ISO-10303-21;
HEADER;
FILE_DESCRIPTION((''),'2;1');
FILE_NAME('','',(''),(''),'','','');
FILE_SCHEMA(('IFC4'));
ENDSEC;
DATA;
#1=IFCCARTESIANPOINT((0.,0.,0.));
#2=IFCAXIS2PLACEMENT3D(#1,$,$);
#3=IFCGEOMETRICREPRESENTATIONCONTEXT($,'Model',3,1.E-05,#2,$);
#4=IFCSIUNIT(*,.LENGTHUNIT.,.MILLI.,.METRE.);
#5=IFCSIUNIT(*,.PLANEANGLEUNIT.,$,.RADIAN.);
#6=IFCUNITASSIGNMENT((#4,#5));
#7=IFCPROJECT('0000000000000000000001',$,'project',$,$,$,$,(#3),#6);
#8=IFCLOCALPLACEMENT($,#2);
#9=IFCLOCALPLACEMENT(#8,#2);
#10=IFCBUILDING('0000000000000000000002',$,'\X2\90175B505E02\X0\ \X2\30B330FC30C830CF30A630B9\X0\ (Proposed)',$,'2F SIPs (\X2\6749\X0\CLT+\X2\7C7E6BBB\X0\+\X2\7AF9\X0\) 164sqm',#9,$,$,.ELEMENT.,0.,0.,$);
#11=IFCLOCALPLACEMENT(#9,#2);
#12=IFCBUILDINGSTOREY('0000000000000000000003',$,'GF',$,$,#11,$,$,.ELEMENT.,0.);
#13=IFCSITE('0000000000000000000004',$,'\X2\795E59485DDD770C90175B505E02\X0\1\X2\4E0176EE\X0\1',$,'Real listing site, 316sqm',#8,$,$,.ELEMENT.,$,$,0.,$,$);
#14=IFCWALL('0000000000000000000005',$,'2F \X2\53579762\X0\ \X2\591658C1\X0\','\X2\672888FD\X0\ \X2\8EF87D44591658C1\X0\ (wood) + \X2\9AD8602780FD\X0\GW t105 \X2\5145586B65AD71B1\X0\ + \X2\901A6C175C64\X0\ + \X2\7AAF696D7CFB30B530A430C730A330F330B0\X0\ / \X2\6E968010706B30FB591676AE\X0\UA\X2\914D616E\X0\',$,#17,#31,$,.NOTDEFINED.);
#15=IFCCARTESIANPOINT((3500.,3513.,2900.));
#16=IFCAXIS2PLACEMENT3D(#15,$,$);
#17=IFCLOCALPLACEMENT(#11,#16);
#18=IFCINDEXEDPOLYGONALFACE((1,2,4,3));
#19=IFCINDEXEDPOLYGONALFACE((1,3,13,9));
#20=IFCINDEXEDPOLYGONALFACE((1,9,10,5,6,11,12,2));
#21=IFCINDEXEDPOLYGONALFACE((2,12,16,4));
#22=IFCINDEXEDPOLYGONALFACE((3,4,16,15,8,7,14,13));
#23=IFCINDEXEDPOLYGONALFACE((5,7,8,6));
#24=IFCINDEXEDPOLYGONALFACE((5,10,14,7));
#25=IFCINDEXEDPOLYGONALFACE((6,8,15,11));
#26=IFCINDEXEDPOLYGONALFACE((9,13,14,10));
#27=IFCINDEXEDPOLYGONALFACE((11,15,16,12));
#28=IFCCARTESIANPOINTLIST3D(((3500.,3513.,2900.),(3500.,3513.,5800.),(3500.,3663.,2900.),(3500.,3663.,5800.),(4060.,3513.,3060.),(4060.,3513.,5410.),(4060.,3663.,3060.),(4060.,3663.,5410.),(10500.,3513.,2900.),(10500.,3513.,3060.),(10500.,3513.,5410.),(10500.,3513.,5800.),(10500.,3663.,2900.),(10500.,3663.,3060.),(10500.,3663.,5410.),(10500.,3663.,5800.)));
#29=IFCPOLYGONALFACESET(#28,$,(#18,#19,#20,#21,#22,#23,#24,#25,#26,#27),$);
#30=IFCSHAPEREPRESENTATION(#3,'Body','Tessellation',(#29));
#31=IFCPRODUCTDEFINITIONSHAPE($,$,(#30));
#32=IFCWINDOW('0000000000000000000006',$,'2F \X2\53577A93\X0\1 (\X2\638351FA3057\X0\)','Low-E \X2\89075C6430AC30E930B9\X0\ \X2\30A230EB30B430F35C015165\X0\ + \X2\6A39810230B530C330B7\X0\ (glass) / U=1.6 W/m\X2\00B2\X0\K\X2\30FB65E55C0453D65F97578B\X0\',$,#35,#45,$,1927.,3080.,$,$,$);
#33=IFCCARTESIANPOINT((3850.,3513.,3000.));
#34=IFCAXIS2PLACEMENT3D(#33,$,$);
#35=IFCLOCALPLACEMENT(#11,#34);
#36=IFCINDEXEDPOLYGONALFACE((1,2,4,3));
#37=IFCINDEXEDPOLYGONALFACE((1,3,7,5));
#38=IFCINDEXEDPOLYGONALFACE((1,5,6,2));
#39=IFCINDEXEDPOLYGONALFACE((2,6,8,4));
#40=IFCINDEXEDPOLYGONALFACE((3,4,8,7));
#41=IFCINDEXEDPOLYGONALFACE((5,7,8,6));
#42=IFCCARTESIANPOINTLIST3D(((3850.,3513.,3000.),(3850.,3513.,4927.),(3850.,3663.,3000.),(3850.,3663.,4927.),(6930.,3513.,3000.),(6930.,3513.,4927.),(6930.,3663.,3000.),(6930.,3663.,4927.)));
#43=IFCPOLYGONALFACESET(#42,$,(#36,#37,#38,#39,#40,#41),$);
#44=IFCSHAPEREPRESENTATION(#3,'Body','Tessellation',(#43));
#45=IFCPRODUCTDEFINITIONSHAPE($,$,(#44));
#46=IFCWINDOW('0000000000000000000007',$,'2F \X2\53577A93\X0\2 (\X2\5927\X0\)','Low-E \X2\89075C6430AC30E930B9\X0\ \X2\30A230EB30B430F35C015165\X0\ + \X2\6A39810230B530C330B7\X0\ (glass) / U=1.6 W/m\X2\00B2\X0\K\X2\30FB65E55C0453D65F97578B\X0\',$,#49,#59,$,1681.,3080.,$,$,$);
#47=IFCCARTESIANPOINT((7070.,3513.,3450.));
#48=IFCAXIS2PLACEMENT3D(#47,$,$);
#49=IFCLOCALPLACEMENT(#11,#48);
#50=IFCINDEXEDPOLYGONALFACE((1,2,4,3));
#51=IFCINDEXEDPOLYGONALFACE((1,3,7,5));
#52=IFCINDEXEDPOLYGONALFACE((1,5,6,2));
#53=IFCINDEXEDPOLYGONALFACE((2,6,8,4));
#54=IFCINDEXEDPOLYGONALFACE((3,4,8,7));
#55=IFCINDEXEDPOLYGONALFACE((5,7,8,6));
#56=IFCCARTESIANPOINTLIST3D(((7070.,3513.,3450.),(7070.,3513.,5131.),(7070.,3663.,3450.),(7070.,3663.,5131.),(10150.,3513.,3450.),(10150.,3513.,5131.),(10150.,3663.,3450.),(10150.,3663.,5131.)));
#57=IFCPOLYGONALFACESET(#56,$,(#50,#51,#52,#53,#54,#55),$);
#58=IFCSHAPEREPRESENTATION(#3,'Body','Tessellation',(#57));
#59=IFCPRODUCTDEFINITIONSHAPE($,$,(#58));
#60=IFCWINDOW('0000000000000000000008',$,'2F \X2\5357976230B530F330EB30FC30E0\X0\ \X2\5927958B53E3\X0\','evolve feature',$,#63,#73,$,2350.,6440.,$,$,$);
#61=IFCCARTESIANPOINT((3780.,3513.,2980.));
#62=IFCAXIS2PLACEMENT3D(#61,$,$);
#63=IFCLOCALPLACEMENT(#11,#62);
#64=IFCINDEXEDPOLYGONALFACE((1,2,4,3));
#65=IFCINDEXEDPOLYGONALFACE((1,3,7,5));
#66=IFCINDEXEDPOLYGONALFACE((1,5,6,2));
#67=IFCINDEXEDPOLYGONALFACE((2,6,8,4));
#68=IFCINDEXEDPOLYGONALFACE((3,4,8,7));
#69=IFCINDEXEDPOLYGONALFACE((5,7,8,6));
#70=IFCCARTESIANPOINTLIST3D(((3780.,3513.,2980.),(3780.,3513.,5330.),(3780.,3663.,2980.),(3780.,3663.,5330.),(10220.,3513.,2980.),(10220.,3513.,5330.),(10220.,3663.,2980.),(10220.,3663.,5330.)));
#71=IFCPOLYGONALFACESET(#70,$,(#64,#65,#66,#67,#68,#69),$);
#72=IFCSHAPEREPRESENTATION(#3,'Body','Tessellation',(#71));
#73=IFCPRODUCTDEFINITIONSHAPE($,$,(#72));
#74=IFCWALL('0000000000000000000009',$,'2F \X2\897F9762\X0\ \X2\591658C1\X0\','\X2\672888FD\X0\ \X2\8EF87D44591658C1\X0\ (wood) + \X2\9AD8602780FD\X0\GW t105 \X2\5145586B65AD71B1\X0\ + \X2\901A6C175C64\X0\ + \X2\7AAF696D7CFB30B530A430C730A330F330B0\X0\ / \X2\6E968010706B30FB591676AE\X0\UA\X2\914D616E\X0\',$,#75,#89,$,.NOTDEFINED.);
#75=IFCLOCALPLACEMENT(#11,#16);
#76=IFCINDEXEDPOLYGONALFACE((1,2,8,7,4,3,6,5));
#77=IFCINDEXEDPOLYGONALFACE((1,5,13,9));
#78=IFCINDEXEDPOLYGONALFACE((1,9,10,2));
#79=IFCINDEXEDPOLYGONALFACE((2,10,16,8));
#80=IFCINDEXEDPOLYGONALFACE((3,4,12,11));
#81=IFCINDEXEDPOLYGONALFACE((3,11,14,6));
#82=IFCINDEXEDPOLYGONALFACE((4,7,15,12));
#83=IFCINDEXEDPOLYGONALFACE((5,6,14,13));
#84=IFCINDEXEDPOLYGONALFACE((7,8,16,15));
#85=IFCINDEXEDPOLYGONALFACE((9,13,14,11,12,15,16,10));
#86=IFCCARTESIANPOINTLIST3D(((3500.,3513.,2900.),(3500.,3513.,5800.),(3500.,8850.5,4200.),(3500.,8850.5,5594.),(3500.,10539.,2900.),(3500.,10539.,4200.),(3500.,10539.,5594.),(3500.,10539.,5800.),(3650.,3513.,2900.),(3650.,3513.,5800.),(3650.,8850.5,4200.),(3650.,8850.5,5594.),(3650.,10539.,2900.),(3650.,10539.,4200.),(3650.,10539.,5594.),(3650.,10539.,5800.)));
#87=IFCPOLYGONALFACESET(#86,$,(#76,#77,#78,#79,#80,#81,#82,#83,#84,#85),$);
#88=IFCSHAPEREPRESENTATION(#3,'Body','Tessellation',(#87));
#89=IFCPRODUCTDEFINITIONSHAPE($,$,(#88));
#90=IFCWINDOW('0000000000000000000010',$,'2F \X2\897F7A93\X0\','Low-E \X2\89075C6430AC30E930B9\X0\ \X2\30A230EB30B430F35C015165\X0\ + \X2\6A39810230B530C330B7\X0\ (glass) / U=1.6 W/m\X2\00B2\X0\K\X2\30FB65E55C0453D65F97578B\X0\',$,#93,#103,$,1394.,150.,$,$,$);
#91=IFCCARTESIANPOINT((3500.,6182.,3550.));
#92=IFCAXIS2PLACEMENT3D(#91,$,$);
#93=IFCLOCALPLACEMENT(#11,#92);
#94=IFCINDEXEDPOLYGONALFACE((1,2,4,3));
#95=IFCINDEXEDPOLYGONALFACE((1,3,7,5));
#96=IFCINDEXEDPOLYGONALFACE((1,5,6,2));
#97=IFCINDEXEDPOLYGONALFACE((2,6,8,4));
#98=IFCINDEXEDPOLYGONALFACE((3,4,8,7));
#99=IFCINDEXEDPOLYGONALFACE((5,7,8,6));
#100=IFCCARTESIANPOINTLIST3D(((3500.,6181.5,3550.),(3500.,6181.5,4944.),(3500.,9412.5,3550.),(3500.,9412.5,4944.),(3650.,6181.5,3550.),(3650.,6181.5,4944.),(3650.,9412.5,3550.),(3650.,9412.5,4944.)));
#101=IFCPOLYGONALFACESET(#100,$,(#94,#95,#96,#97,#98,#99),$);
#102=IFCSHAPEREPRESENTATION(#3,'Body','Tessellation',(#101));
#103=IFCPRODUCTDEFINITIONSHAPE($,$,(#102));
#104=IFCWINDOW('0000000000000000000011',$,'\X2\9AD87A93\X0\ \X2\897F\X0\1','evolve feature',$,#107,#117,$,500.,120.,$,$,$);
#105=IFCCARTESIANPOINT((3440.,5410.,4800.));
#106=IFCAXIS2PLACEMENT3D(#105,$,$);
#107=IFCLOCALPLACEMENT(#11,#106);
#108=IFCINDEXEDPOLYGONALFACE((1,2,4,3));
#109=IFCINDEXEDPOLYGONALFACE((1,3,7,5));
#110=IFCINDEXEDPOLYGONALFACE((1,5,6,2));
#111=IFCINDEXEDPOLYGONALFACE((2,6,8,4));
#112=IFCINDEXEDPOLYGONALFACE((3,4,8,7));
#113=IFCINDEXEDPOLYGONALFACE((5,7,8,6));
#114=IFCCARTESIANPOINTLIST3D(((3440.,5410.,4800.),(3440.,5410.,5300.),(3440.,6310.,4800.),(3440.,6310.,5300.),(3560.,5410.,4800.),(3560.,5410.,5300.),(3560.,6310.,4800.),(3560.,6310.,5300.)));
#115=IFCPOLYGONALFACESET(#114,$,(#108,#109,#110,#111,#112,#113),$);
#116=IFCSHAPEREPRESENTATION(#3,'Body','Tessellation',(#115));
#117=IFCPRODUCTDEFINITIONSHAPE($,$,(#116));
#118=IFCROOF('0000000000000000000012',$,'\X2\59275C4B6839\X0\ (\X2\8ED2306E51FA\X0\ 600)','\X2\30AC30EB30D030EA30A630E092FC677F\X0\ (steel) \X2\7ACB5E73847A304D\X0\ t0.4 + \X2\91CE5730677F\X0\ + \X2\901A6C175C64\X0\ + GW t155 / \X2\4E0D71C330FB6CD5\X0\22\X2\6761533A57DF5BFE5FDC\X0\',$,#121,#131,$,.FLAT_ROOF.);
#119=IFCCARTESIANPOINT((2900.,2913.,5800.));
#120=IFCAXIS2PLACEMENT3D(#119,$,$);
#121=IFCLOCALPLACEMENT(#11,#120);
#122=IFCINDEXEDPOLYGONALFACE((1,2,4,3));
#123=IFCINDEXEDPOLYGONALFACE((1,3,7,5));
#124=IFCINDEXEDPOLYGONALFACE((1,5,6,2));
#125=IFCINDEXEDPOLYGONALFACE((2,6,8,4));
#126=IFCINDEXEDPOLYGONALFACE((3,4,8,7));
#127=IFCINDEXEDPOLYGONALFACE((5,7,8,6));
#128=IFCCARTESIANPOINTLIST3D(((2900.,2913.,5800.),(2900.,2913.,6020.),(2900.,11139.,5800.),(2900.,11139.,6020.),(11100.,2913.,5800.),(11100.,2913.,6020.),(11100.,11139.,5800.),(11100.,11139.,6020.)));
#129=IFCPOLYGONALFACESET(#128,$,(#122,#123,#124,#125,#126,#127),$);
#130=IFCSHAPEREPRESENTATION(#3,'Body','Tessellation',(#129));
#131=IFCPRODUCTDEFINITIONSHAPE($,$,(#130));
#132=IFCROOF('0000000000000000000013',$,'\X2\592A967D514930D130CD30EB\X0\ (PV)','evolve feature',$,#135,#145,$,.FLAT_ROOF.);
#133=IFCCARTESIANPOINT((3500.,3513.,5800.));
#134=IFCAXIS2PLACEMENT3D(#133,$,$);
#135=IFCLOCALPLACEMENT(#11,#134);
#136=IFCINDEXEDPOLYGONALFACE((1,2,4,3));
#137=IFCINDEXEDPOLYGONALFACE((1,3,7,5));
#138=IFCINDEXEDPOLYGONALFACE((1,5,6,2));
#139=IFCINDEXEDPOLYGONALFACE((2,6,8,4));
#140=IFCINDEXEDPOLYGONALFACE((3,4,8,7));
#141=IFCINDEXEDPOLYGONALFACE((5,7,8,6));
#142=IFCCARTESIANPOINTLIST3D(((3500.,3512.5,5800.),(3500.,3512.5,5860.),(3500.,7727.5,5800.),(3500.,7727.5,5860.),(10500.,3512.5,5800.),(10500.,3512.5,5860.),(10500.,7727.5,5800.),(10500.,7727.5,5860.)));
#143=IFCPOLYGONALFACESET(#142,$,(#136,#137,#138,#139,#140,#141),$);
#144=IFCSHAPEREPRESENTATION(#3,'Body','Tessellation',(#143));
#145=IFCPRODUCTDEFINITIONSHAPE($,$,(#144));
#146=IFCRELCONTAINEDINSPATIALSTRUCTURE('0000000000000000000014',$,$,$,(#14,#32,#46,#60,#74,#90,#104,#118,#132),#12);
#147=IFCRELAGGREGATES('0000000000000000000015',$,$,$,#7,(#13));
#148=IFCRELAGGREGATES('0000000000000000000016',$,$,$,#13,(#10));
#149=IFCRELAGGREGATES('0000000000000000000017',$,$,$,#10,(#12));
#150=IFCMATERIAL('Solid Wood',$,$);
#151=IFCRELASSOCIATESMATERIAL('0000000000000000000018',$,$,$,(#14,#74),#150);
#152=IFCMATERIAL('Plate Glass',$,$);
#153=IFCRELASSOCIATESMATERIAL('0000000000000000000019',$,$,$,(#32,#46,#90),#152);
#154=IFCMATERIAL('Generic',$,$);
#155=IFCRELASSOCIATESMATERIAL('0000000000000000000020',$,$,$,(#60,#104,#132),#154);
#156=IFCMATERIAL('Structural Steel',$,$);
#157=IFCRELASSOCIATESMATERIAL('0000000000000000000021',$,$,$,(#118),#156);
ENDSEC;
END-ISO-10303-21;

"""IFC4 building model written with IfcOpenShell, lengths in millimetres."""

from ifc_helpers import new_model, si_unit, frame, frame_2d, origin, place, context, project, spatial, rectangle, extrude, material, element, fill, save


model = new_model("IFC4")

# Units and contexts
model_context = context("Model", 3, precision=1e-05, world=origin())
ifc_project = project(units=[si_unit("LENGTHUNIT", "METRE", prefix="MILLI"), si_unit("PLANEANGLEUNIT", "RADIAN")], contexts=[model_context])

# Site, building, storey
site_placement = place(None, origin())
site = spatial("IfcSite", under=ifc_project, at=site_placement, Name="神奈川県逗子市1丁目1", ObjectType="Real listing site, 316sqm", CompositionType="ELEMENT", RefElevation=0.0)
building_placement = place(site_placement, origin())
building = spatial("IfcBuilding", under=site, at=building_placement, Name="逗子市 コートハウス (Proposed)", ObjectType="2F SIPs (杉CLT+籾殻+竹) 164sqm", CompositionType="ELEMENT", ElevationOfRefHeight=0.0, ElevationOfTerrain=0.0)
storey_placement = place(building_placement, origin())
storey = spatial("IfcBuildingStorey", under=building, at=storey_placement, Name="GF", CompositionType="ELEMENT", Elevation=0.0)

# Shared definitions
ifc_material_1 = material(Name="Solid Wood")
ifc_material_2 = material(Name="Generic")

# Shared definitions
ifc_material_3 = material(Name="Plate Glass")

# Walls, openings, windows
wall_1_placement = place(storey_placement, frame((3500.0, 3513.0, 2900.0)))
wall_1 = element("IfcWall", 1, at=wall_1_placement, inside=storey, material=ifc_material_1, Name="2F 南面 外壁", Description="木製 軸組外壁 (wood) + 高性能GW t105 充填断熱 + 通気層 + 窯業系サイディング / 準耐火・外皮UA配慮", PredefinedType="NOTDEFINED", context=model_context, shape_type="SweptSolid", body=[
    extrude(rectangle(XDim=7000.0, YDim=150.0, at=frame_2d((3500.0, 75.0))), frame((3500.0, 3513.0, 2900.0)), (0.0, 0.0, 1.0), 2900.0),
])
opening_1_placement = place(storey_placement, frame((3850.0, 3513.0, 3000.0)))
opening_1 = element("IfcOpeningElement", 2, at=opening_1_placement, cuts=wall_1, PredefinedType="NOTDEFINED", context=model_context, shape_type="SweptSolid", body=[
    extrude(rectangle(XDim=3080.0, YDim=150.0, at=frame_2d((1540.0, 75.0))), frame((3850.0, 3513.0, 3000.0)), (0.0, 0.0, 1.0), 1927.0),
])
opening_2_placement = place(storey_placement, frame((7070.0, 3513.0, 3450.0)))
opening_2 = element("IfcOpeningElement", 3, at=opening_2_placement, cuts=wall_1, PredefinedType="NOTDEFINED", context=model_context, shape_type="SweptSolid", body=[
    extrude(rectangle(XDim=3080.0, YDim=150.0, at=frame_2d((1540.0, 75.0))), frame((7070.0, 3513.0, 3450.0)), (0.0, 0.0, 1.0), 1681.0),
])
opening_3_placement = place(storey_placement, frame((3780.0, 3513.0, 2980.0)))
opening_3 = element("IfcOpeningElement", 4, at=opening_3_placement, cuts=wall_1, PredefinedType="NOTDEFINED", context=model_context, shape_type="SweptSolid", body=[
    extrude(rectangle(XDim=6440.0, YDim=150.0, at=frame_2d((3220.0, 75.0))), frame((3780.0, 3513.0, 2980.0)), (0.0, 0.0, 1.0), 2350.0),
])
window_1_placement = place(storey_placement, frame((3850.0, 3513.0, 3000.0)))
window_1 = element("IfcWindow", 5, at=window_1_placement, inside=storey, material=ifc_material_3, Name="2F 南窓1 (掃出し)", Description="Low-E 複層ガラス アルゴン封入 + 樹脂サッシ (glass) / U=1.6 W/m²K・日射取得型", OverallHeight=1927.0, OverallWidth=3080.0, context=model_context, shape_type="SweptSolid", body=[
    extrude(rectangle(XDim=3080.0, YDim=150.0, at=frame_2d((1540.0, 75.0))), frame((3850.0, 3513.0, 3000.0)), (0.0, 0.0, 1.0), 1927.0),
])
fill(opening_1, window_1)
window_2_placement = place(storey_placement, frame((7070.0, 3513.0, 3450.0)))
window_2 = element("IfcWindow", 6, at=window_2_placement, inside=storey, material=ifc_material_3, Name="2F 南窓2 (大)", Description="Low-E 複層ガラス アルゴン封入 + 樹脂サッシ (glass) / U=1.6 W/m²K・日射取得型", OverallHeight=1681.0, OverallWidth=3080.0, context=model_context, shape_type="SweptSolid", body=[
    extrude(rectangle(XDim=3080.0, YDim=150.0, at=frame_2d((1540.0, 75.0))), frame((7070.0, 3513.0, 3450.0)), (0.0, 0.0, 1.0), 1681.0),
])
fill(opening_2, window_2)
window_3_placement = place(storey_placement, frame((3780.0, 3513.0, 2980.0)))
window_3 = element("IfcWindow", 7, at=window_3_placement, inside=storey, material=ifc_material_2, Name="2F 南面サンルーム 大開口", Description="evolve feature", OverallHeight=2350.0, OverallWidth=6440.0, context=model_context, shape_type="SweptSolid", body=[
    extrude(rectangle(XDim=6440.0, YDim=150.0, at=frame_2d((3220.0, 75.0))), frame((3780.0, 3513.0, 2980.0)), (0.0, 0.0, 1.0), 2350.0),
])
fill(opening_3, window_3)
wall_2_placement = place(storey_placement, frame((3500.0, 3513.0, 2900.0)))
wall_2 = element("IfcWall", 8, at=wall_2_placement, inside=storey, material=ifc_material_1, Name="2F 西面 外壁", Description="木製 軸組外壁 (wood) + 高性能GW t105 充填断熱 + 通気層 + 窯業系サイディング / 準耐火・外皮UA配慮", PredefinedType="NOTDEFINED", context=model_context, shape_type="SweptSolid", body=[
    extrude(rectangle(XDim=150.0, YDim=7026.0, at=frame_2d((75.0, 3513.0))), frame((3500.0, 3513.0, 2900.0)), (0.0, 0.0, 1.0), 2900.0),
])
opening_4_placement = place(storey_placement, frame((3500.0, 6182.0, 3550.0)))
opening_4 = element("IfcOpeningElement", 9, at=opening_4_placement, cuts=wall_2, PredefinedType="NOTDEFINED", context=model_context, shape_type="SweptSolid", body=[
    extrude(rectangle(XDim=150.0, YDim=3231.0, at=frame_2d((75.0, 1615.0))), frame((3500.0, 6182.0, 3550.0)), (0.0, 0.0, 1.0), 1394.0),
])
opening_5_placement = place(storey_placement, frame((3440.0, 5410.0, 4800.0)))
opening_5 = element("IfcOpeningElement", 10, at=opening_5_placement, cuts=wall_2, PredefinedType="NOTDEFINED", context=model_context, shape_type="SweptSolid", body=[
    extrude(rectangle(XDim=120.0, YDim=900.0, at=frame_2d((60.0, 450.0))), frame((3440.0, 5410.0, 4800.0)), (0.0, 0.0, 1.0), 500.0),
])
window_4_placement = place(storey_placement, frame((3500.0, 6182.0, 3550.0)))
window_4 = element("IfcWindow", 11, at=window_4_placement, inside=storey, material=ifc_material_3, Name="2F 西窓", Description="Low-E 複層ガラス アルゴン封入 + 樹脂サッシ (glass) / U=1.6 W/m²K・日射取得型", OverallHeight=1394.0, OverallWidth=150.0, context=model_context, shape_type="SweptSolid", body=[
    extrude(rectangle(XDim=150.0, YDim=3231.0, at=frame_2d((75.0, 1615.0))), frame((3500.0, 6182.0, 3550.0)), (0.0, 0.0, 1.0), 1394.0),
])
fill(opening_4, window_4)
window_5_placement = place(storey_placement, frame((3440.0, 5410.0, 4800.0)))
window_5 = element("IfcWindow", 12, at=window_5_placement, inside=storey, material=ifc_material_2, Name="高窓 西1", Description="evolve feature", OverallHeight=500.0, OverallWidth=120.0, context=model_context, shape_type="SweptSolid", body=[
    extrude(rectangle(XDim=120.0, YDim=900.0, at=frame_2d((60.0, 450.0))), frame((3440.0, 5410.0, 4800.0)), (0.0, 0.0, 1.0), 500.0),
])
fill(opening_5, window_5)

# Roofs
ifc_material_4 = material(Name="Structural Steel")
roof_1_placement = place(storey_placement, frame((2900.0, 2913.0, 5800.0)))
element("IfcRoof", 13, at=roof_1_placement, inside=storey, material=ifc_material_4, Name="大屋根 (軒の出 600)", Description="ガルバリウム鋼板 (steel) 立平葺き t0.4 + 野地板 + 通気層 + GW t155 / 不燃・法22条区域対応", PredefinedType="FLAT_ROOF", context=model_context, shape_type="SweptSolid", body=[
    extrude(rectangle(XDim=8200.0, YDim=8226.0, at=frame_2d((4100.0, 4113.0))), frame((2900.0, 2913.0, 5800.0)), (0.0, 0.0, 1.0), 220.0),
])
roof_2_placement = place(storey_placement, frame((3500.0, 3513.0, 5800.0)))
element("IfcRoof", 14, at=roof_2_placement, inside=storey, material=ifc_material_2, Name="太陽光パネル (PV)", Description="evolve feature", PredefinedType="FLAT_ROOF", context=model_context, shape_type="SweptSolid", body=[
    extrude(rectangle(XDim=7000.0, YDim=4215.0, at=frame_2d((3500.0, 2107.0))), frame((3500.0, 3513.0, 5800.0)), (0.0, 0.0, 1.0), 60.0),
])

save(model, "model.ifc")
